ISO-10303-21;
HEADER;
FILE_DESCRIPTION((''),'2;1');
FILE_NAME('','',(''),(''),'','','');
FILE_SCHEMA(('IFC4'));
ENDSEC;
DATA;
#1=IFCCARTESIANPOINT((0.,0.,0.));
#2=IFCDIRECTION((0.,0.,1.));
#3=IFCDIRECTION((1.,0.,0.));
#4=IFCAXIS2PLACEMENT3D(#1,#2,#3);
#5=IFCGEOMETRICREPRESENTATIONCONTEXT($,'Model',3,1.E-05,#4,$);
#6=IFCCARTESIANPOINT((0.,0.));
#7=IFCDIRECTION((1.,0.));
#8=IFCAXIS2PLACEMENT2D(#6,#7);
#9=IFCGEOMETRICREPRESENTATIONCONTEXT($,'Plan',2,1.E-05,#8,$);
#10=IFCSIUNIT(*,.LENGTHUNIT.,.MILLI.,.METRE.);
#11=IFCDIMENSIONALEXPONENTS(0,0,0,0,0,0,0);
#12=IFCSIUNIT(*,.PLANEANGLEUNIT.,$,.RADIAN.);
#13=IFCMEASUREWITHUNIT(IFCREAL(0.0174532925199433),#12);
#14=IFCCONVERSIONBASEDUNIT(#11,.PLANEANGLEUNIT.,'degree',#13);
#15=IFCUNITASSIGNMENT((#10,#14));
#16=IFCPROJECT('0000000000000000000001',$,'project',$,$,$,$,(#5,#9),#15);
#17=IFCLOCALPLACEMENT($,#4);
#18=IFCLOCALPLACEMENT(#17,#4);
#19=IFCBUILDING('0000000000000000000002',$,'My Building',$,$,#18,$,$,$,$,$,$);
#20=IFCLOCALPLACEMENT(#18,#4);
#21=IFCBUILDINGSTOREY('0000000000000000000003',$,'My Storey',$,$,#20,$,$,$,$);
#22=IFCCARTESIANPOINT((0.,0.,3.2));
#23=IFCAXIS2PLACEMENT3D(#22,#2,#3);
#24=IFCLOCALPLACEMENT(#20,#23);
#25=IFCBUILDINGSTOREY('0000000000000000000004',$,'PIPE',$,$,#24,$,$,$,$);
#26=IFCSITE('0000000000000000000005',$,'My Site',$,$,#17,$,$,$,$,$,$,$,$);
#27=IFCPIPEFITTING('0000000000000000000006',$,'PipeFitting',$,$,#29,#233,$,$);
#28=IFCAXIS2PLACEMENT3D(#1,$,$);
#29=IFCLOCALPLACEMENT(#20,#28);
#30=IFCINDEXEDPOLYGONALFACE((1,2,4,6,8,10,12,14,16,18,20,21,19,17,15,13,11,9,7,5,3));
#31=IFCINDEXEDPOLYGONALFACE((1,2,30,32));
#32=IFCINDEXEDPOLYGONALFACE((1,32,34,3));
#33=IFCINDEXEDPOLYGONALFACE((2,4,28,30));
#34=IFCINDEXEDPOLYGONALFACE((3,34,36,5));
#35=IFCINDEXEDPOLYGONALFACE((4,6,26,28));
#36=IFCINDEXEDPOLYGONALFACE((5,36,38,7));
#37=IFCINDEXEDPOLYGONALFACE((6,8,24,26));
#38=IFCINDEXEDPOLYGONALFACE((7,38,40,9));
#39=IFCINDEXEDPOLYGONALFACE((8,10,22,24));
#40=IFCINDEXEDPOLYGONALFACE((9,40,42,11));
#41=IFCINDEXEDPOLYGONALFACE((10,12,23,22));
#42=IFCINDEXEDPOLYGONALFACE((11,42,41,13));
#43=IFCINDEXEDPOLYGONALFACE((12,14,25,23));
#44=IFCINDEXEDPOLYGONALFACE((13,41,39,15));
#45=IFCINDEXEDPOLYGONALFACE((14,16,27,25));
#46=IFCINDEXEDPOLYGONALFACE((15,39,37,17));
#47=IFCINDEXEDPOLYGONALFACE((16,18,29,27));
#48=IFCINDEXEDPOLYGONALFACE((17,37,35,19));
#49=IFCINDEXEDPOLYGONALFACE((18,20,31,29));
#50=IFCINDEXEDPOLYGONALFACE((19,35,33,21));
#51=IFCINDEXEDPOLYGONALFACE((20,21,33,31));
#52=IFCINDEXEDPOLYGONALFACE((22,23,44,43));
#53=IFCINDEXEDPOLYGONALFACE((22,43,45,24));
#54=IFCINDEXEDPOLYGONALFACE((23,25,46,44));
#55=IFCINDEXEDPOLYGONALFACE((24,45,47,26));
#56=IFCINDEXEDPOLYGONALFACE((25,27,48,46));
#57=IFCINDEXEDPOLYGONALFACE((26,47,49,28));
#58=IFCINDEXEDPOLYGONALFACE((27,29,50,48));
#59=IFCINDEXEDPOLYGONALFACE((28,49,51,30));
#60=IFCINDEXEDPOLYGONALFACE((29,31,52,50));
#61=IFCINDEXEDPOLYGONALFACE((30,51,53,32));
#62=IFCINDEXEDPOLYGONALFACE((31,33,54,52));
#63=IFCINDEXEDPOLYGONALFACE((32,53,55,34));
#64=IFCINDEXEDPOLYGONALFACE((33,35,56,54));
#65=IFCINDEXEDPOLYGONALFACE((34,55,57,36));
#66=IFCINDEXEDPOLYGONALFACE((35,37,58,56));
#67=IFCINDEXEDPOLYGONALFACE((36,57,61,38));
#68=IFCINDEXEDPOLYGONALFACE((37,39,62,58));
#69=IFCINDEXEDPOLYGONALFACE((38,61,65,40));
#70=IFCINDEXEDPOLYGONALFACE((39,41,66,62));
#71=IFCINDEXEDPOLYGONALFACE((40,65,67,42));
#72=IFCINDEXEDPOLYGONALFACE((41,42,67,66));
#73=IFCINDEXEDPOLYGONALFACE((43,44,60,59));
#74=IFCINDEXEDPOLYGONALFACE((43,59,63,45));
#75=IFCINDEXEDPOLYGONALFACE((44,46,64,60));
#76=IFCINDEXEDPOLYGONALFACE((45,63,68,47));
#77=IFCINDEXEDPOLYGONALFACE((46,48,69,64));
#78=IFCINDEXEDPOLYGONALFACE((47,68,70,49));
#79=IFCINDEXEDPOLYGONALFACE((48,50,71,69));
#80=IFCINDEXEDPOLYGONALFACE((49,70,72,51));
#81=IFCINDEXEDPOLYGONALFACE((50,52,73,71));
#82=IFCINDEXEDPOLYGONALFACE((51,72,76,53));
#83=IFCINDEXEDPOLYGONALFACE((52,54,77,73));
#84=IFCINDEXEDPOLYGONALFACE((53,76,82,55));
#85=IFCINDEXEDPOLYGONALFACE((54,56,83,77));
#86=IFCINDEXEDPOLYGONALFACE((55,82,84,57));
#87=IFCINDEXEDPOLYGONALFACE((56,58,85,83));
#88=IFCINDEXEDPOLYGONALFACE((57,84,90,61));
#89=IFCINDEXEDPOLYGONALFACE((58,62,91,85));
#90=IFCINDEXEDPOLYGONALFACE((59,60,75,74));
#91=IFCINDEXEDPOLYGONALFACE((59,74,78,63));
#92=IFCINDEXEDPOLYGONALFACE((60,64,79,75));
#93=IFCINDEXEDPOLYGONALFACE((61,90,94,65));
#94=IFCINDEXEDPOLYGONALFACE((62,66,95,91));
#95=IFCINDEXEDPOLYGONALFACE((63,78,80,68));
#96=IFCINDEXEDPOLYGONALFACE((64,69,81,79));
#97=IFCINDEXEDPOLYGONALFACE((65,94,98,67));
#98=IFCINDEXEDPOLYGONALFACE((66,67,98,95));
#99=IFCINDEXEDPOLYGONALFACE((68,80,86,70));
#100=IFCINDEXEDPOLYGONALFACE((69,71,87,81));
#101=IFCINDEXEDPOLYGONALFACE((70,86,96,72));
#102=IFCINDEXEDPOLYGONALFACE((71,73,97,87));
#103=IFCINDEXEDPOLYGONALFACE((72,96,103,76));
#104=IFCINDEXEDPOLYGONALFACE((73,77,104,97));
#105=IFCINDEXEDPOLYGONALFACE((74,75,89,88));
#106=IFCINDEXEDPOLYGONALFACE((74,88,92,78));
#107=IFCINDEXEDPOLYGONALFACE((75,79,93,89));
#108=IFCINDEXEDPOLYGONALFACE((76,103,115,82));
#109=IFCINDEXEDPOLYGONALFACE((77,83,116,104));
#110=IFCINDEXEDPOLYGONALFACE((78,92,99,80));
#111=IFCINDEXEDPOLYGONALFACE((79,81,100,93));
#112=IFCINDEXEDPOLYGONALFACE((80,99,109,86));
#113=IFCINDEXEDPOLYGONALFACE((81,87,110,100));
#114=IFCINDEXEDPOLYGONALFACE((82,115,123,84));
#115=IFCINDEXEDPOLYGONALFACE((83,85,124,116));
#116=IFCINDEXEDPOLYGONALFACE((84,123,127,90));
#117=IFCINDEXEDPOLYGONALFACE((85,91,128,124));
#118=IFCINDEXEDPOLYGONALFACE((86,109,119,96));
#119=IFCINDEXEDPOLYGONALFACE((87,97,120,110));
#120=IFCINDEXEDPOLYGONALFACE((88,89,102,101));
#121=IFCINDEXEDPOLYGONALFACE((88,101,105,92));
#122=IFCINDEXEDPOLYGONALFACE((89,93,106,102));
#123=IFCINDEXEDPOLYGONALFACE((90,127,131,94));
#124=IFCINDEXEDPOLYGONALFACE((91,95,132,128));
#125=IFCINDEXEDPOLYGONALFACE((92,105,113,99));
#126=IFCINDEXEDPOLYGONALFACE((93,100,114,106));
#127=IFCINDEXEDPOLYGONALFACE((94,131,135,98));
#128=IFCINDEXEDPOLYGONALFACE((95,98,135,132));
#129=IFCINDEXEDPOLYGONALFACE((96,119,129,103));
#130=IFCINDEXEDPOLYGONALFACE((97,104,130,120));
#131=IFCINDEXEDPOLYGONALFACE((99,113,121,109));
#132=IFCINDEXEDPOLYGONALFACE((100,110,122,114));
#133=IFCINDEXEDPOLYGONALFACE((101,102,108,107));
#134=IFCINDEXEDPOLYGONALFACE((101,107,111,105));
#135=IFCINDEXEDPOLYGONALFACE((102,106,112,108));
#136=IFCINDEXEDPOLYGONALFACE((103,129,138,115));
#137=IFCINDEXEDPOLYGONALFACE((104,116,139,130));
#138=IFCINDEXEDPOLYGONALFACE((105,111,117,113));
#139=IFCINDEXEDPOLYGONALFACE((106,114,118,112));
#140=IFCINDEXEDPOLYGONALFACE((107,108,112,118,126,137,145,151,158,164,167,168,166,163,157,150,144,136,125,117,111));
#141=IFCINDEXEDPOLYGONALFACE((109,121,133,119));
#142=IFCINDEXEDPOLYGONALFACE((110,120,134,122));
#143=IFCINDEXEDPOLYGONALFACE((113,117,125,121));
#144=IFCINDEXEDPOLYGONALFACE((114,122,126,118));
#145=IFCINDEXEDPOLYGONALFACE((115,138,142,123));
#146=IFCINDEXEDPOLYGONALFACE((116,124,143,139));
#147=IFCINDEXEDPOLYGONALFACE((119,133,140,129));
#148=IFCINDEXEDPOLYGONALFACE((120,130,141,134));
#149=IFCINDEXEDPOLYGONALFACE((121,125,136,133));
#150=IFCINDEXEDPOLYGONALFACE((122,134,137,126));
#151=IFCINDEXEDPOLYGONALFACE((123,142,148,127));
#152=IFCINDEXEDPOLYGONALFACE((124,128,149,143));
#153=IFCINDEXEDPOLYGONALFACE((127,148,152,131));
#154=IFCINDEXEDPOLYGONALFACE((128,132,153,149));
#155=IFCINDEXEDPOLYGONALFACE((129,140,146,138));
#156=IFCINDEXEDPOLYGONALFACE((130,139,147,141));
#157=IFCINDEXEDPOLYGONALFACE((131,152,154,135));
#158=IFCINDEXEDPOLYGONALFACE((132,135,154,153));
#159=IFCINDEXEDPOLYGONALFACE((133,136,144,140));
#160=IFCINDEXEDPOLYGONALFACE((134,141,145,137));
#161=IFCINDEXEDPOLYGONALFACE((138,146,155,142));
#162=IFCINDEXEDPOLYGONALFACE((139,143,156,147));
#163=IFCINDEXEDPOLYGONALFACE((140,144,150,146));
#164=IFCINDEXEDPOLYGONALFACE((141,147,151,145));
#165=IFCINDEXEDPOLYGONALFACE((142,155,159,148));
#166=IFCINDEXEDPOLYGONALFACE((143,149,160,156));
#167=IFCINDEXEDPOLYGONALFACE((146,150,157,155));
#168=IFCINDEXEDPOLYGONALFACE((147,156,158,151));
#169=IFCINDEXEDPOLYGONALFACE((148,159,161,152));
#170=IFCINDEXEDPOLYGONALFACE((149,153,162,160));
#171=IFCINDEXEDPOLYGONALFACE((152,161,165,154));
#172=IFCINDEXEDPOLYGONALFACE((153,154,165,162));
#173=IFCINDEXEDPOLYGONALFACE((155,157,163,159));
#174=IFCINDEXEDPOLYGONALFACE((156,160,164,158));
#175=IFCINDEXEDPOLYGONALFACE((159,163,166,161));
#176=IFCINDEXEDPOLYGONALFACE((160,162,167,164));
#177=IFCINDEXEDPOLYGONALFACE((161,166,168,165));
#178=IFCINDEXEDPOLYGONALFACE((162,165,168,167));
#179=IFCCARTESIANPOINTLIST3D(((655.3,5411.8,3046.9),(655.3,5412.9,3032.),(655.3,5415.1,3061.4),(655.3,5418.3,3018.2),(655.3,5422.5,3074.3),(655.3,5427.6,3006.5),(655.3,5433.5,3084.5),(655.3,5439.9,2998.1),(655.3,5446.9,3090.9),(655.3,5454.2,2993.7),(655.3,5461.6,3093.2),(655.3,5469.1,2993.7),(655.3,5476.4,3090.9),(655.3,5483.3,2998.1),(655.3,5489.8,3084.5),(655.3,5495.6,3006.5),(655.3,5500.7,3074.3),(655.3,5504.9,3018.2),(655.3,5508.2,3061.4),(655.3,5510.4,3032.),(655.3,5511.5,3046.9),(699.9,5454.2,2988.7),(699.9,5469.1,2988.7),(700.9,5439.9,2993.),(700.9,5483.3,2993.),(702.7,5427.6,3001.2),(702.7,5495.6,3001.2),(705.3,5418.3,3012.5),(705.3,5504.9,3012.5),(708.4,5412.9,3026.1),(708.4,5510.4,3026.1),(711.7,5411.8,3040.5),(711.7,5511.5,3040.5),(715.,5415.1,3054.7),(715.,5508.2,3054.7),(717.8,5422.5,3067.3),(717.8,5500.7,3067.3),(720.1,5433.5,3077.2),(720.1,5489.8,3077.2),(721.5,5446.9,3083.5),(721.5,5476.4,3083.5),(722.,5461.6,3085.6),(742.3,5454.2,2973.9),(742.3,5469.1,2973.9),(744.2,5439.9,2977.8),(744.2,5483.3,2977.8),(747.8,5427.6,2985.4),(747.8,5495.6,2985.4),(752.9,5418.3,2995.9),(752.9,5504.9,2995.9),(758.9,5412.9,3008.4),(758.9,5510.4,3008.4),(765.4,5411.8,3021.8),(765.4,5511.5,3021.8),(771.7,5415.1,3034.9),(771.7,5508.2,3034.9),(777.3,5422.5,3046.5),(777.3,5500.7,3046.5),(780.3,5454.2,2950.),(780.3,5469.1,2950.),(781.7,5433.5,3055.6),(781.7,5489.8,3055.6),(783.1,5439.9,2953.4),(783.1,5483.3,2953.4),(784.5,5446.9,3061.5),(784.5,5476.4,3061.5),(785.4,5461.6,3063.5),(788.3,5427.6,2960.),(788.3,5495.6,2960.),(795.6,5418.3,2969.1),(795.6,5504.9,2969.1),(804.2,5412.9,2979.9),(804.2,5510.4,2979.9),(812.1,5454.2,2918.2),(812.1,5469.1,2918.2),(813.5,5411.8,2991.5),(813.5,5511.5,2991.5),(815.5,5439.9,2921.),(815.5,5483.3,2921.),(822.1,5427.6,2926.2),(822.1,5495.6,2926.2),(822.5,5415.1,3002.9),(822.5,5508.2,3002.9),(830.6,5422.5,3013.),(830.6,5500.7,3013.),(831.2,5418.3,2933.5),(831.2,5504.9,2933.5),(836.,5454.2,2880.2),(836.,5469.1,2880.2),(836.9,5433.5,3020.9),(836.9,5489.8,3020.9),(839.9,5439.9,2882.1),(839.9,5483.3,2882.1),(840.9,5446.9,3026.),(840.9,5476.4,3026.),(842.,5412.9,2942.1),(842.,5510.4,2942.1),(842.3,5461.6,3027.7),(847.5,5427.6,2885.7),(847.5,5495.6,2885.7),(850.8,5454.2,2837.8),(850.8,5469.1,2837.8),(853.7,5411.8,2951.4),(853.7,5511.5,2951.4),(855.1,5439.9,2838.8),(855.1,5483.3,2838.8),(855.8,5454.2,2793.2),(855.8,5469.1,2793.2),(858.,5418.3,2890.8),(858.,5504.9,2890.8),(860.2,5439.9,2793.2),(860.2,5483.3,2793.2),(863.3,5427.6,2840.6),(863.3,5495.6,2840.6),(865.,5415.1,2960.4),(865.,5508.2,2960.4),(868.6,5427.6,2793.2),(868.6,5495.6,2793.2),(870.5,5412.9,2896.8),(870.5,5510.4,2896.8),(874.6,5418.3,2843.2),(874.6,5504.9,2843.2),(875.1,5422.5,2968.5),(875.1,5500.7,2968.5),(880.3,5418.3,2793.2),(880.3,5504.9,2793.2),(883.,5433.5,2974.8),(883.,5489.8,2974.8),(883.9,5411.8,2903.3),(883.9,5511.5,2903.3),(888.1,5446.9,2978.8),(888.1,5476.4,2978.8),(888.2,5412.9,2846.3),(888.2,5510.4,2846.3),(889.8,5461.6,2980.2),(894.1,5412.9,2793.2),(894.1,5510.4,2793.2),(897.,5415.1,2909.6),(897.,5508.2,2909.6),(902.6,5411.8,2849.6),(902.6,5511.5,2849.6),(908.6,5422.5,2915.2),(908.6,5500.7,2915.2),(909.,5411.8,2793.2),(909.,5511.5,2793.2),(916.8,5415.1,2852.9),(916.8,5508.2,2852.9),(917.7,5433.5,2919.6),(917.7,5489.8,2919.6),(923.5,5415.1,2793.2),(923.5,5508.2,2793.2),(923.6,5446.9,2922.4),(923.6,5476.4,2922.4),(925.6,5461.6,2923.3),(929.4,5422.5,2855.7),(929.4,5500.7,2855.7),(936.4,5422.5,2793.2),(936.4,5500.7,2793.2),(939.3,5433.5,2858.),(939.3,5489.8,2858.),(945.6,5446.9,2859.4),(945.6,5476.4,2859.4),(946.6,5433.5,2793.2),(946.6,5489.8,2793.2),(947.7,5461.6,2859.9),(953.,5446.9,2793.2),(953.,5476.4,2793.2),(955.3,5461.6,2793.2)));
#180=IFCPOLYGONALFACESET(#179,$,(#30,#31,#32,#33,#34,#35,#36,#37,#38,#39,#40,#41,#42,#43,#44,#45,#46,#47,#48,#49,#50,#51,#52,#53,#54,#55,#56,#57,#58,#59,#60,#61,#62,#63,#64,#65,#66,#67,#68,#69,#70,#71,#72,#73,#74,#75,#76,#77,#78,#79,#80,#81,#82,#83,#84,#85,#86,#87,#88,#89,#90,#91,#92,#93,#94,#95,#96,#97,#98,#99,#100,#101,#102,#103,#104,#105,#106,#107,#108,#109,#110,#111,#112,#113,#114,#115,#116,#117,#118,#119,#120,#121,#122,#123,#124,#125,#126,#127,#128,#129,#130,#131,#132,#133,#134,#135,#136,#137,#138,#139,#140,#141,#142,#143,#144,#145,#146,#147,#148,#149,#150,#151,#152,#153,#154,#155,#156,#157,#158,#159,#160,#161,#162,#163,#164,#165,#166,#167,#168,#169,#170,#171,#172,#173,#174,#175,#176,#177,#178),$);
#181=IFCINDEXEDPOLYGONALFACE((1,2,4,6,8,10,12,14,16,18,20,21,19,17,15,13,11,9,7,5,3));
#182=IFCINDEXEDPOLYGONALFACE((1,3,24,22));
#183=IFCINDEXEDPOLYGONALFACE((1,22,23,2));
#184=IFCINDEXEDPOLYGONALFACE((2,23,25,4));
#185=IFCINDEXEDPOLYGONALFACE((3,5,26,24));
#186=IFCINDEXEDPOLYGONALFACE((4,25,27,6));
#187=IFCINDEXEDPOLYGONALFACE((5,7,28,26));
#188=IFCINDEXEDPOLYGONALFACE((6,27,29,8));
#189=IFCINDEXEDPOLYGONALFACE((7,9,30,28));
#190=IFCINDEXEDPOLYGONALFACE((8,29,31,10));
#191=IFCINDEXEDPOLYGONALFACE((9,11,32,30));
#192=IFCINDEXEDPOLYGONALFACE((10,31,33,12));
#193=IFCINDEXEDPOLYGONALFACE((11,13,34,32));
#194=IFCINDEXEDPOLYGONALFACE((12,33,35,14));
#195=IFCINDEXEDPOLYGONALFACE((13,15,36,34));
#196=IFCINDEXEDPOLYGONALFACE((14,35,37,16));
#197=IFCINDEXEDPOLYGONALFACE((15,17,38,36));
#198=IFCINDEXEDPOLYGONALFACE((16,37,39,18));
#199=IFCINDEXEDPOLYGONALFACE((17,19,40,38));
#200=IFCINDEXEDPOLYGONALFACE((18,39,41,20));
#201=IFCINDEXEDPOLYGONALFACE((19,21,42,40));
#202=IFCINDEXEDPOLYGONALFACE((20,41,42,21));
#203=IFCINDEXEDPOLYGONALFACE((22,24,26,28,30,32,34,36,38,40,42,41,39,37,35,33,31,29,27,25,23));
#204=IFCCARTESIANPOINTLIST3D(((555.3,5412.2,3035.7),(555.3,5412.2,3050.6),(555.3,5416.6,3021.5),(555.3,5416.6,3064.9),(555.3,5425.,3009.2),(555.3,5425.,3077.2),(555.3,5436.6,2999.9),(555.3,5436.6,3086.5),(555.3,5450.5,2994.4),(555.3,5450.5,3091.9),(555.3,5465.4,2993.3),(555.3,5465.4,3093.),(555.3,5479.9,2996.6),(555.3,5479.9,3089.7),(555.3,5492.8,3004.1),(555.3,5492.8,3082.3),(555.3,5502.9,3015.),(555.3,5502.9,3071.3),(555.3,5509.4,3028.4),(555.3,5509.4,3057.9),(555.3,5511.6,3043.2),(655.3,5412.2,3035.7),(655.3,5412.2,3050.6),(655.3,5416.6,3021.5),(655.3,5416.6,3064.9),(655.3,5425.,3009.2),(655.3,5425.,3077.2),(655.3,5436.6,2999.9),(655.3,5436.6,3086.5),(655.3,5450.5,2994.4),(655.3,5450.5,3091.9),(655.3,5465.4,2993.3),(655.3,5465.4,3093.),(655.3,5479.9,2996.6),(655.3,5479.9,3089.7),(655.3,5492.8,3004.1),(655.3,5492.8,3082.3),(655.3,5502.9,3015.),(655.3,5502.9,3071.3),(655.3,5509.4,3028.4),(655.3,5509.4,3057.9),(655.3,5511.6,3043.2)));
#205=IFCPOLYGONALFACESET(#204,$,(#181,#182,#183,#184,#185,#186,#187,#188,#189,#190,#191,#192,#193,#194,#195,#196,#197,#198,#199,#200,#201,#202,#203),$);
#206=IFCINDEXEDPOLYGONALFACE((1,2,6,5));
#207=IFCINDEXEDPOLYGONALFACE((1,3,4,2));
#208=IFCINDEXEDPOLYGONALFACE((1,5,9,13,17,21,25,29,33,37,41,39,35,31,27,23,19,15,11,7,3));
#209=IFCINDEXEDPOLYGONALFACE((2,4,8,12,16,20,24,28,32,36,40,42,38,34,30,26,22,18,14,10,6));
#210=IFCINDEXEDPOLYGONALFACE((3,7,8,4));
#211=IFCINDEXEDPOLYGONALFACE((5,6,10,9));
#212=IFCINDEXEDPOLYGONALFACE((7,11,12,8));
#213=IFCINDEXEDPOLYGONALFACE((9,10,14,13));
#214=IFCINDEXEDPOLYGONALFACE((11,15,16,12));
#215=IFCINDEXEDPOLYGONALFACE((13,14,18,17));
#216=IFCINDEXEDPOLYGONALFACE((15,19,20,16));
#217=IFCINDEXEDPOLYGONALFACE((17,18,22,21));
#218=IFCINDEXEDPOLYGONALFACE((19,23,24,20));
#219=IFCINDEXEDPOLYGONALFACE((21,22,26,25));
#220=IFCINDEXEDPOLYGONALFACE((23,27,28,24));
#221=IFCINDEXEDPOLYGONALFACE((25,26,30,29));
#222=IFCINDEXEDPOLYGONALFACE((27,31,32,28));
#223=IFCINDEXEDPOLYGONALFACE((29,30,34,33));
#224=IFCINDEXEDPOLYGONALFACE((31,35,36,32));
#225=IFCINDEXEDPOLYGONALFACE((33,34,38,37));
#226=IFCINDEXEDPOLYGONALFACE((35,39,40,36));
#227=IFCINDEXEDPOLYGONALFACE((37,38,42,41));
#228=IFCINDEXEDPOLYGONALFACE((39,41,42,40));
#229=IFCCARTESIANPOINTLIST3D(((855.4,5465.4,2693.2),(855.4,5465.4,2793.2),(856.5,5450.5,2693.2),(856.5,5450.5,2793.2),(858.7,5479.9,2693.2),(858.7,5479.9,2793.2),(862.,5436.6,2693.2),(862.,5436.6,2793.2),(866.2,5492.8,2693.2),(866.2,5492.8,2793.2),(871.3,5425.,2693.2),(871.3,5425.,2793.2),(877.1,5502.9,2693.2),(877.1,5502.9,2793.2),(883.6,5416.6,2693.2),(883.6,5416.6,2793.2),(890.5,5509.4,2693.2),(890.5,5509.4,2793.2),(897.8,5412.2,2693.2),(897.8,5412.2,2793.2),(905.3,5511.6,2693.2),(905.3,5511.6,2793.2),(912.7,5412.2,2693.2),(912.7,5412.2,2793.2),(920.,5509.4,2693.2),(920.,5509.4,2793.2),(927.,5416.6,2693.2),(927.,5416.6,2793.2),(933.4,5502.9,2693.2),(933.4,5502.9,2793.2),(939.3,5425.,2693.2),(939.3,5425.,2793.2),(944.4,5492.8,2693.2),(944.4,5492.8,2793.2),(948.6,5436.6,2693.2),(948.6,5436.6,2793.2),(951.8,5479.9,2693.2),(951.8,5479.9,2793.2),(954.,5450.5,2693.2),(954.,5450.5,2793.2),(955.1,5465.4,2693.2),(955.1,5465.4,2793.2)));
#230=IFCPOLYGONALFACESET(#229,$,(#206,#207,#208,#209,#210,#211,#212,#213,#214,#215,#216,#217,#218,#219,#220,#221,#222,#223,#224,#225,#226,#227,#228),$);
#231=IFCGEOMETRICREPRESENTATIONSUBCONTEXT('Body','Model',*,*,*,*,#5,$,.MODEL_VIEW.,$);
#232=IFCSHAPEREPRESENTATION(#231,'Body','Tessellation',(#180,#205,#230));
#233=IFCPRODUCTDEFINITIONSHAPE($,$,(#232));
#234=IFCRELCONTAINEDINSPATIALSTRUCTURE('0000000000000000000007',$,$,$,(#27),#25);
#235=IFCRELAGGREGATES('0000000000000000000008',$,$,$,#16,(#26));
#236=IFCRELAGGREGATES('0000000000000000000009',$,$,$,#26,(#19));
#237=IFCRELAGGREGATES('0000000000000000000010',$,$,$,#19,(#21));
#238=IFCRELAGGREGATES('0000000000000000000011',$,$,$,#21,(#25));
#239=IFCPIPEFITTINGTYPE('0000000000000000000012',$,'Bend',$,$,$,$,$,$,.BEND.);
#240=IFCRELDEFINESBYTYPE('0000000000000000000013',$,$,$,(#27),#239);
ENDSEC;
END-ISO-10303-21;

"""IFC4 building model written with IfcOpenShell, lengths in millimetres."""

from ifc_helpers import new_model, entity, si_unit, converted_unit, frame, origin_with_axes, origin_2d_with_axis, place, context, subcontext, project, spatial, circle, extrude, source, transform, mapped, type_object, type_shapes, element, save


model = new_model("IFC4")

# Units and contexts
model_context = context("Model", 3, precision=1e-05, world=origin_with_axes())
plan_context = context("Plan", 2, precision=1e-05, world=origin_2d_with_axis())
body_context = subcontext(model_context, "Body", "Model", "MODEL_VIEW")
ifc_project = project(units=[si_unit("LENGTHUNIT", "METRE", prefix="MILLI"), converted_unit("PLANEANGLEUNIT", "degree", entity("IfcReal", 0.0174532925199433), si_unit("PLANEANGLEUNIT", "RADIAN"), dimensions=[0, 0, 0, 0, 0, 0, 0])], contexts=[model_context, plan_context])

# Site, building, storeys
site_placement = place(None, origin_with_axes())
site = spatial("IfcSite", under=ifc_project, at=site_placement, Name="My Site")
building_placement = place(site_placement, origin_with_axes())
building = spatial("IfcBuilding", under=site, at=building_placement, Name="My Building")
storey_1_placement = place(building_placement, origin_with_axes())
storey_1 = spatial("IfcBuildingStorey", under=building, at=storey_1_placement, Name="My Storey")
storey_2_placement = place(storey_1_placement, frame((0.0, 0.0, 3.2), z_axis=(0.0, 0.0, 1.0), x_axis=(1.0, 0.0, 0.0)))
storey_2 = spatial("IfcBuildingStorey", under=storey_1, at=storey_2_placement, Name="PIPE")

# Pipe fitting
pipe_fitting_type = type_object("IfcPipeFittingType", Name="Bend", PredefinedType="BEND")
shared_shape = source(origin_with_axes(), body_context, "Body", "SolidModel", [
    entity("IfcSweptDiskSolid", entity("IfcIndexedPolyCurve", entity("IfcCartesianPointList3D", [[0.0, 0.0, 100.0], [0.0, -73.2, 276.8], [0.0, -250.0, 350.0]]), [entity("IfcArcIndex", [1, 2, 3])]), 50.0),
    extrude(circle(Radius=50.0), origin_with_axes(), (0.0, 0.0, 1.0), 100.0),
    extrude(circle(Radius=50.0), frame((0.0, -250.0, 350.0), z_axis=(0.0, -1.0, 0.0), x_axis=(1.0, 0.0, 0.0)), (0.0, 0.0, 1.0), 100.0),
])
type_shapes(pipe_fitting_type, [shared_shape])
for number, where, z_axis, x_axis, name in (
    (1, (555.3, 5461.6, 3040.0), (1.0, 0.0, 0.0), (0.0, 1.0, 0.0), "PipeFitting"),
):
    element("IfcPipeFitting", number, at=place(storey_2_placement, frame(where, z_axis=z_axis, x_axis=x_axis)), inside=storey_2, type_object=pipe_fitting_type, Name=name, context=body_context, shape_type="MappedRepresentation", body=[
        mapped(shared_shape, transform((0.0, 0.0, 0.0), x_axis=(1.0, 0.0, 0.0), y_axis=(0.0, 1.0, 0.0), z_axis=(0.0, 0.0, 1.0), scale=1.0)),
    ])

save(model, "model.ifc")
